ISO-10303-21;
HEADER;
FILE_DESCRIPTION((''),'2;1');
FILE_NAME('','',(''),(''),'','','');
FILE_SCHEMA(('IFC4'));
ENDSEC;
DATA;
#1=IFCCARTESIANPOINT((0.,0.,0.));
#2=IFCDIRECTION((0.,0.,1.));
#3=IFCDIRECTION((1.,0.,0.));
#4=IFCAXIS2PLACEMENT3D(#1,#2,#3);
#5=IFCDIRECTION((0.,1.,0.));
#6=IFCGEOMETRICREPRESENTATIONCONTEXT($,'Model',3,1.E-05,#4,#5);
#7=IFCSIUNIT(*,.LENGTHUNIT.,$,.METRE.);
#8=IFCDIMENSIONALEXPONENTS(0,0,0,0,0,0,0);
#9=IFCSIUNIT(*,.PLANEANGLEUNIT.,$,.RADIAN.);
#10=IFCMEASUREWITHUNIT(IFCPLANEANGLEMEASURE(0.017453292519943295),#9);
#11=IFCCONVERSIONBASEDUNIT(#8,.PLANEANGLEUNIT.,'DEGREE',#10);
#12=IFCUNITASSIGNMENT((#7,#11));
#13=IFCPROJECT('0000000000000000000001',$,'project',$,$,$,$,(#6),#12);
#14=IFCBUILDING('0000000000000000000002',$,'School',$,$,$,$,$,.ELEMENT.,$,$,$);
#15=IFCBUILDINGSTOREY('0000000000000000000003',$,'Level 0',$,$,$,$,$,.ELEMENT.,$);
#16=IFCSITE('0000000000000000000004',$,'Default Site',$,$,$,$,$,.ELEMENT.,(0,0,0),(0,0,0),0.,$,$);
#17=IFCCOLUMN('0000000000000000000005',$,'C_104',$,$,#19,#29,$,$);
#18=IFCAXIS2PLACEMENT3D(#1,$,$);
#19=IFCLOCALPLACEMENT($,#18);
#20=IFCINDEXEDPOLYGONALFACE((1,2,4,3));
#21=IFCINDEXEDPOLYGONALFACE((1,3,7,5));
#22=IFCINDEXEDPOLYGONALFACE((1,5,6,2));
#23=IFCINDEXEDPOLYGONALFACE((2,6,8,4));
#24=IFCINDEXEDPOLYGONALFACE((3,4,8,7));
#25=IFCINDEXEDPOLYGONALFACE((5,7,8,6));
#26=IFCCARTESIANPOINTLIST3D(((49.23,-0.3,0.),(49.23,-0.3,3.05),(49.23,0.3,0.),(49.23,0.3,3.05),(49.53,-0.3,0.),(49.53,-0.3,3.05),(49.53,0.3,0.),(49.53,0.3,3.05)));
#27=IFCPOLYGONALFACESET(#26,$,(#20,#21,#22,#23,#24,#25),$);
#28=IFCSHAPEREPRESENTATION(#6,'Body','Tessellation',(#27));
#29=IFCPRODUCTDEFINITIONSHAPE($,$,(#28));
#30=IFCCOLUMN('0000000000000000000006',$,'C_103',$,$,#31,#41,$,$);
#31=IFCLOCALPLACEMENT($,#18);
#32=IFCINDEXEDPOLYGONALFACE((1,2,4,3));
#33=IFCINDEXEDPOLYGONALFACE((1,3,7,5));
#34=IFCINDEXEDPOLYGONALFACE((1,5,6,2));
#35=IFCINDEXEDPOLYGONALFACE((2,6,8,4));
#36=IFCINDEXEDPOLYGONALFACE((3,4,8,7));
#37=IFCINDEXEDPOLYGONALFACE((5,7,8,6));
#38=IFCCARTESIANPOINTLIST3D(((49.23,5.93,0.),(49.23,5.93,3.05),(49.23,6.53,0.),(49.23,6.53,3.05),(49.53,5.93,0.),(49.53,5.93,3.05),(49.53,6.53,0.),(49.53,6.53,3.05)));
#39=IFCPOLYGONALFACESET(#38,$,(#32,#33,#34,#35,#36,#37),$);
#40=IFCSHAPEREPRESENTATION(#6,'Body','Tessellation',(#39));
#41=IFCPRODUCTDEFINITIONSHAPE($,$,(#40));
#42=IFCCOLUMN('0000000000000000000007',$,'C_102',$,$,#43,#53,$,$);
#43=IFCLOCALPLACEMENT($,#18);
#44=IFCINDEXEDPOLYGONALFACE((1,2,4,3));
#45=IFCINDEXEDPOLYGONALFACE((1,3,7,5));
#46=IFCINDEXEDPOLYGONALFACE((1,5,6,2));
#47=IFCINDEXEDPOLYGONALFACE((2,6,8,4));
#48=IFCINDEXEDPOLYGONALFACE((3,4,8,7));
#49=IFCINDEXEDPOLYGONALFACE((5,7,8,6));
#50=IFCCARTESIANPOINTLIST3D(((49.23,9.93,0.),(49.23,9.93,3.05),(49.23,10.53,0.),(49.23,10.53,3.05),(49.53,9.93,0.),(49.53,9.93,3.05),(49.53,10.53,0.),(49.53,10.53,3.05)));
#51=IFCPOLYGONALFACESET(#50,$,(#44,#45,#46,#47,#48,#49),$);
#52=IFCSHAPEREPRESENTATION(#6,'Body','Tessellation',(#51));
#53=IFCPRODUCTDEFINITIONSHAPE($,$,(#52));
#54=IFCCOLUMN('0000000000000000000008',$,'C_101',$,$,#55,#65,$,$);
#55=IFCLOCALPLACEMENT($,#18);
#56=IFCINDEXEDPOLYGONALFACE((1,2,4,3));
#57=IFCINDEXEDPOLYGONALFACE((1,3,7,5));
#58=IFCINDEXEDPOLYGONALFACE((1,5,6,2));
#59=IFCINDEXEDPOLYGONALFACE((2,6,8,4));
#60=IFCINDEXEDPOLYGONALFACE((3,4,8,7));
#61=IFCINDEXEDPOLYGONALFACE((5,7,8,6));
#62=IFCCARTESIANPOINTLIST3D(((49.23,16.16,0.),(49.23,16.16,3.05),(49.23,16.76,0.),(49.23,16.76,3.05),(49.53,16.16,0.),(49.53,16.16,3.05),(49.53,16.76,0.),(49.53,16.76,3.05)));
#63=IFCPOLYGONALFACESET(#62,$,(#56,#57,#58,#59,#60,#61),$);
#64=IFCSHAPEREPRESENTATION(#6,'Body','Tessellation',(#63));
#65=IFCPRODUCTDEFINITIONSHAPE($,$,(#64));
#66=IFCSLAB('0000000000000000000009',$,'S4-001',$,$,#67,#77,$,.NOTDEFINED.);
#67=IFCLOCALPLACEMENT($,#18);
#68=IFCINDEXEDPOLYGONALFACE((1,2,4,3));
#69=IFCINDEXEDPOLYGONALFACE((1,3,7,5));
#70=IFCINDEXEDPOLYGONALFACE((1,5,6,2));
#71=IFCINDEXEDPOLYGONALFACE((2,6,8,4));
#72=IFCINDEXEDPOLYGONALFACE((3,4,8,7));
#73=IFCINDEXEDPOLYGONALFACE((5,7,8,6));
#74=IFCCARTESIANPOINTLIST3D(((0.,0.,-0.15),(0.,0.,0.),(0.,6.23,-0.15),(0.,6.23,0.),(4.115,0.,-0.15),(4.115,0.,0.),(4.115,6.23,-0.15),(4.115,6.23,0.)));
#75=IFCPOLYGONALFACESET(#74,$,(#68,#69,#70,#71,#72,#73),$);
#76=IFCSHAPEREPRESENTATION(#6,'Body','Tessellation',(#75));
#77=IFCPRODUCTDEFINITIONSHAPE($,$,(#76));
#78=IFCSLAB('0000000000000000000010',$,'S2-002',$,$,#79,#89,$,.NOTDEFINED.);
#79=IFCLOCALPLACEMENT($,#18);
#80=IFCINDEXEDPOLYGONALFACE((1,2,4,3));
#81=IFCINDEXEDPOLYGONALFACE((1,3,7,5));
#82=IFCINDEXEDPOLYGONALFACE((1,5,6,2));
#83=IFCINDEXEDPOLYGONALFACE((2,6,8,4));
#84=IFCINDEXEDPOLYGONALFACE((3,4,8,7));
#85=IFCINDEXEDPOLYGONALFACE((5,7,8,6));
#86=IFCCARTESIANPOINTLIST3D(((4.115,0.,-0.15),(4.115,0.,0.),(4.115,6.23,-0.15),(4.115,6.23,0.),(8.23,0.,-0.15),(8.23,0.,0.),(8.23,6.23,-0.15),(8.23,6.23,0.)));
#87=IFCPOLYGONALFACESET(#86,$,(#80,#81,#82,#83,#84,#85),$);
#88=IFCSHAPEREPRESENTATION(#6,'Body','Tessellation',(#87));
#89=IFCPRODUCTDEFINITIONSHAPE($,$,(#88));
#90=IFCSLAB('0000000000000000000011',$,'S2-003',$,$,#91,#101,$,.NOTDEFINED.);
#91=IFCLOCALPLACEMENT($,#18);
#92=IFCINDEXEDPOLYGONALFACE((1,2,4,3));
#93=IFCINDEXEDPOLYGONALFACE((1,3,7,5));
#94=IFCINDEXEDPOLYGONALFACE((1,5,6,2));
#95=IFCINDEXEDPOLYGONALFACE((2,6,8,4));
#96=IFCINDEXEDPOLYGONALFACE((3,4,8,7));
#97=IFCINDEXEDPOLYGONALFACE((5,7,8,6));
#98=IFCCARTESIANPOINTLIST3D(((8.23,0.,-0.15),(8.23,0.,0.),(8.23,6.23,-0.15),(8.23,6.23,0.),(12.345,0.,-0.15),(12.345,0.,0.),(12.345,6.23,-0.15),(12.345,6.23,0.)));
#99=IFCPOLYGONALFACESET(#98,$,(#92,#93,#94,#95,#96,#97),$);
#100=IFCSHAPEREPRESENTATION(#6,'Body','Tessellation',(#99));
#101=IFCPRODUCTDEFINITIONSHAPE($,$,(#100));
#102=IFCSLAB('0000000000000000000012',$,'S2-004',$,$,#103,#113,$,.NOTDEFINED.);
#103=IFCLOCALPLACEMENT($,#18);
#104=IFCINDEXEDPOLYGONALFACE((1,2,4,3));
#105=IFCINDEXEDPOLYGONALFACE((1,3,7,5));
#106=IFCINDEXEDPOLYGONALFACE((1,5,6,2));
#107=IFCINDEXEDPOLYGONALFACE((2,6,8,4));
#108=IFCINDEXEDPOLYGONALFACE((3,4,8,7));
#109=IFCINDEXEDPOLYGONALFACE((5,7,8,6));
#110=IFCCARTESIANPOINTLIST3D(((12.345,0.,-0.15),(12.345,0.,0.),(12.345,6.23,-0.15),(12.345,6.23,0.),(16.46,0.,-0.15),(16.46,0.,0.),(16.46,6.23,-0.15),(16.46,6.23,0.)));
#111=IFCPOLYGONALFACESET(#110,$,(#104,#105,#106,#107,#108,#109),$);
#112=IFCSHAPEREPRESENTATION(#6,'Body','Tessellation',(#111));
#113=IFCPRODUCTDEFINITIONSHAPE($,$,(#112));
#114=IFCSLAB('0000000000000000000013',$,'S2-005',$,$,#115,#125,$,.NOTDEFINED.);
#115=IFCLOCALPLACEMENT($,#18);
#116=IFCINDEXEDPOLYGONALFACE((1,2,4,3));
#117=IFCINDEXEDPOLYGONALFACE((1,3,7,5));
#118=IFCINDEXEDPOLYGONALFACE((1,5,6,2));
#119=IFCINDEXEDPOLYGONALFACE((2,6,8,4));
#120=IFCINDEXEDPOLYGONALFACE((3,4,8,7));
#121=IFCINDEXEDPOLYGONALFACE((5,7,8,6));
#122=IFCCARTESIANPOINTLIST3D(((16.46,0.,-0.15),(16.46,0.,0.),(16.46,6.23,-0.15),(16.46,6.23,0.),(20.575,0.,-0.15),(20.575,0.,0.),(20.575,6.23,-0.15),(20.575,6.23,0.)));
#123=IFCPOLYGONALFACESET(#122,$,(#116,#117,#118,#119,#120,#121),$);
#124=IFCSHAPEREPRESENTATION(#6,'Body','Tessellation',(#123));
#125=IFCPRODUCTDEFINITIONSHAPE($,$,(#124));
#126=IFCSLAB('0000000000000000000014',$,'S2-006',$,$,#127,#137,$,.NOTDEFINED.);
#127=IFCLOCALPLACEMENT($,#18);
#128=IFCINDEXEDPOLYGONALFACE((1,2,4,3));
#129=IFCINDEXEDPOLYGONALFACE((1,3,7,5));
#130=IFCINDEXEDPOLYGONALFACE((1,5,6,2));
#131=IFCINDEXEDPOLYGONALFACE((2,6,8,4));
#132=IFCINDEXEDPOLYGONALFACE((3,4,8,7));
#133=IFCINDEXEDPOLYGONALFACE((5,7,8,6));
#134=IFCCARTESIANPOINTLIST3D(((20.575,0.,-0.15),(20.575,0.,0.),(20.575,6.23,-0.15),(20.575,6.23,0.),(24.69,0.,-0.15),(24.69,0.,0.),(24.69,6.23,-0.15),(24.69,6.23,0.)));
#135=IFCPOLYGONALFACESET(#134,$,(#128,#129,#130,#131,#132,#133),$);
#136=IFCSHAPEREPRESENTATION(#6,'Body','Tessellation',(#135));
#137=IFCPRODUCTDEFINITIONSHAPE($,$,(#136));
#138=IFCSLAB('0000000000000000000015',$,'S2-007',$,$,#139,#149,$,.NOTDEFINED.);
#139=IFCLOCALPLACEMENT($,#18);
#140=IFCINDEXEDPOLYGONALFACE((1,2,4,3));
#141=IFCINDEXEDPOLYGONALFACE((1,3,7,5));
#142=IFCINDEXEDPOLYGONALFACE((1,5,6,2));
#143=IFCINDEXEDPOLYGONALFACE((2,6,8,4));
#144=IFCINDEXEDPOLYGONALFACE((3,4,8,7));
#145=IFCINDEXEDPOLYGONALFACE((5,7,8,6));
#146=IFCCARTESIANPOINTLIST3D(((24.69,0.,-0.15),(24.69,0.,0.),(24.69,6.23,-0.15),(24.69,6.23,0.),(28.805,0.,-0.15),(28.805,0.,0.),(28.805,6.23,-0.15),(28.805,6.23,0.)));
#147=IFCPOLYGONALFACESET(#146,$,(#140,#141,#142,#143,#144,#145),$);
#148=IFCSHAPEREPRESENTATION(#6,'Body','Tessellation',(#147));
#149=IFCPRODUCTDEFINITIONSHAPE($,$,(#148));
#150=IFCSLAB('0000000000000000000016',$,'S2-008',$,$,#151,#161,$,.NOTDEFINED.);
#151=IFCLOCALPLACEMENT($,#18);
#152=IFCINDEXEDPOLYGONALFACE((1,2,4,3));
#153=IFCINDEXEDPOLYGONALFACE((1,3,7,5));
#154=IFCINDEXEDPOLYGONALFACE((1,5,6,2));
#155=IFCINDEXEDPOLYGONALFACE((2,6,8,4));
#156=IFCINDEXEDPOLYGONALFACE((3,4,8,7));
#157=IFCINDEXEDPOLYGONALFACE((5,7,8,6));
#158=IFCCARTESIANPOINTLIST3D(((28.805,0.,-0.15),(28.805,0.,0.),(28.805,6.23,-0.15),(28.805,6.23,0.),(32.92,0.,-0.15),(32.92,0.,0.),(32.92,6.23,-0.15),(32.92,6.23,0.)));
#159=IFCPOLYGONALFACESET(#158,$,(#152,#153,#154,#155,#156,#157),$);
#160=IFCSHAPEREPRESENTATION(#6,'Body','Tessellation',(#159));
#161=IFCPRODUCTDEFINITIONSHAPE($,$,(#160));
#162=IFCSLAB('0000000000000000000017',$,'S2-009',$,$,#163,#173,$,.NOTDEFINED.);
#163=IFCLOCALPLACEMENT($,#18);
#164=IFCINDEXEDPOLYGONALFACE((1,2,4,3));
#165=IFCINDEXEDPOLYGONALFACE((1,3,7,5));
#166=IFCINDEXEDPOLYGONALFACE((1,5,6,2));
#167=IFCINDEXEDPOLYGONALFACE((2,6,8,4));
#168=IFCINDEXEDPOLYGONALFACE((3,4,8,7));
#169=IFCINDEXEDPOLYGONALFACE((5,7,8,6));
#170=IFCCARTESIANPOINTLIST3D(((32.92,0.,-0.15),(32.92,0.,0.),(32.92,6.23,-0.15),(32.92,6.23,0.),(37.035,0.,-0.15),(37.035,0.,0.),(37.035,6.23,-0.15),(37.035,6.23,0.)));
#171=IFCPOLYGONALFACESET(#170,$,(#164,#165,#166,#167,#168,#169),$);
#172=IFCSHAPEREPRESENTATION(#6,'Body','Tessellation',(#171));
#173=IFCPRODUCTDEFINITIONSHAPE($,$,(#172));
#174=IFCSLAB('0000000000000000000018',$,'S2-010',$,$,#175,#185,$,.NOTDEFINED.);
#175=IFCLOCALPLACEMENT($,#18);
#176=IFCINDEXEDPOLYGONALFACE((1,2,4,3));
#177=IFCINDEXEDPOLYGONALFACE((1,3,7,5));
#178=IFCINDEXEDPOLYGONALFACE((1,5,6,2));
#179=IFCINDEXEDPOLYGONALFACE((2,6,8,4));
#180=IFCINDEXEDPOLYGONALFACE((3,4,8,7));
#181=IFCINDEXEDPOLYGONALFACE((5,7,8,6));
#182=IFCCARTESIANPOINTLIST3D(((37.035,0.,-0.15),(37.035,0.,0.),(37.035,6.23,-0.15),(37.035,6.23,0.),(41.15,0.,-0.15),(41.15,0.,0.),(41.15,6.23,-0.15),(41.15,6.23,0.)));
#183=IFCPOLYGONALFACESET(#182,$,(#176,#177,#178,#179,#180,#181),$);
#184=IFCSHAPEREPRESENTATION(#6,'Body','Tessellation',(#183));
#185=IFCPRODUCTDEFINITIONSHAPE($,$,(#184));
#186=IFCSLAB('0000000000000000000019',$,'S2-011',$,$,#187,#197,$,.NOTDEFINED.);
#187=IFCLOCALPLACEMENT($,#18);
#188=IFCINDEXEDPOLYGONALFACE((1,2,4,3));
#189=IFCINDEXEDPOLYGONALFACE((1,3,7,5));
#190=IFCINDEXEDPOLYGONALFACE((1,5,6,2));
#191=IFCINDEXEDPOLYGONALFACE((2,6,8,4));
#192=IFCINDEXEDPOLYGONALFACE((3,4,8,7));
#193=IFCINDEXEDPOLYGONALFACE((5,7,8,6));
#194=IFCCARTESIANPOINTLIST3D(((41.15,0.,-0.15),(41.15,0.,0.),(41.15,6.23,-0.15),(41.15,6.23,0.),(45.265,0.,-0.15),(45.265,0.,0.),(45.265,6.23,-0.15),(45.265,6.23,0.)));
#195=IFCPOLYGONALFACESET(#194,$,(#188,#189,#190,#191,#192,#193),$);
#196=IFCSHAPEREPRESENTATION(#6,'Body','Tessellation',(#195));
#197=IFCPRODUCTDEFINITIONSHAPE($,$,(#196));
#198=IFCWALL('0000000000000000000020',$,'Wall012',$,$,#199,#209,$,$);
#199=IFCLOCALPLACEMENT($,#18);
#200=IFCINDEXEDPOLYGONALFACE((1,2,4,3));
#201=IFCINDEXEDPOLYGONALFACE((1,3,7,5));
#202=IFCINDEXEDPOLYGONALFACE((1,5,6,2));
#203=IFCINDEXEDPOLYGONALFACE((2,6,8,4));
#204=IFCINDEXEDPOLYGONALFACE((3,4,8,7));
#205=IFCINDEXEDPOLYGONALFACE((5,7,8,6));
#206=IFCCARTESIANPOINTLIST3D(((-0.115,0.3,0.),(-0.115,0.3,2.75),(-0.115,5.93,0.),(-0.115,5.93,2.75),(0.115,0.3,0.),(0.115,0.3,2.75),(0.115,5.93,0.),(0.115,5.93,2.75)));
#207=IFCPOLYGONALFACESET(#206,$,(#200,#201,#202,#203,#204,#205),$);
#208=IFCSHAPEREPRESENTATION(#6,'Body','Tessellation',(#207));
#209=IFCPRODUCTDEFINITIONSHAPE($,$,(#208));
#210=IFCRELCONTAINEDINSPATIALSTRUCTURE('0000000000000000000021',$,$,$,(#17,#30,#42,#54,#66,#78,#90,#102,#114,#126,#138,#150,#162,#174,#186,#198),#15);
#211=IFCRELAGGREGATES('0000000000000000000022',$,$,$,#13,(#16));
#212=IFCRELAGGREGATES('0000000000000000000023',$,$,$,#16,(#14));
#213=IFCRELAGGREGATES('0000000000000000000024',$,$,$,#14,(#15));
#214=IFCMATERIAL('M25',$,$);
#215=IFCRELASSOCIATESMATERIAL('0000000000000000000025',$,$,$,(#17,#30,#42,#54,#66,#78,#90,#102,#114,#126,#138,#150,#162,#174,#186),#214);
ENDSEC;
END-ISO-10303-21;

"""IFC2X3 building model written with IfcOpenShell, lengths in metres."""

from ifc_helpers import new_model, entity, si_unit, converted_unit, direction, frame, frame_2d, origin_with_axes, place, context, project, spatial, rectangle, extrude, material, element, save


model = new_model("IFC2X3")

# Units and contexts
model_context = context("Model", 3, precision=1e-05, world=origin_with_axes(), true_north=direction((0.0, 1.0, 0.0)))
ifc_project = project(units=[si_unit("LENGTHUNIT", "METRE"), converted_unit("PLANEANGLEUNIT", "DEGREE", entity("IfcPlaneAngleMeasure", 0.017453292519943295), si_unit("PLANEANGLEUNIT", "RADIAN"), dimensions=[0, 0, 0, 0, 0, 0, 0])], contexts=[model_context])

# Site, building, storey
site = spatial("IfcSite", under=ifc_project, Name="Default Site", CompositionType="ELEMENT", RefLatitude=(0, 0, 0), RefLongitude=(0, 0, 0), RefElevation=0.0)
building = spatial("IfcBuilding", under=site, Name="School", CompositionType="ELEMENT")
storey = spatial("IfcBuildingStorey", under=building, Name="Level 0", CompositionType="ELEMENT")

# Columns
ifc_material = material(Name="M25")
placement = place(None, origin_with_axes())
element("IfcColumn", 1, at=placement, inside=storey, material=ifc_material, Name="C_104", context=model_context, shape_type="SweptSolid", body=[
    extrude(rectangle(XDim=0.3, YDim=0.6, at=frame_2d((0.0, 0.0), x_axis=(1.0, 0.0, 0.0))), frame((49.38, 0.0, 0.0), z_axis=(0.0, 0.0, 1.0), x_axis=(1.0, 0.0, 0.0)), (0.0, 0.0, 1.0), 3.05),
])
element("IfcColumn", 2, at=placement, inside=storey, material=ifc_material, Name="C_103", context=model_context, shape_type="SweptSolid", body=[
    extrude(rectangle(XDim=0.3, YDim=0.6, at=frame_2d((0.0, 0.0), x_axis=(1.0, 0.0, 0.0))), frame((49.38, 6.23, 0.0), z_axis=(0.0, 0.0, 1.0), x_axis=(1.0, 0.0, 0.0)), (0.0, 0.0, 1.0), 3.05),
])
element("IfcColumn", 3, at=placement, inside=storey, material=ifc_material, Name="C_102", context=model_context, shape_type="SweptSolid", body=[
    extrude(rectangle(XDim=0.3, YDim=0.6, at=frame_2d((0.0, 0.0), x_axis=(1.0, 0.0, 0.0))), frame((49.38, 10.23, 0.0), z_axis=(0.0, 0.0, 1.0), x_axis=(1.0, 0.0, 0.0)), (0.0, 0.0, 1.0), 3.05),
])
element("IfcColumn", 4, at=placement, inside=storey, material=ifc_material, Name="C_101", context=model_context, shape_type="SweptSolid", body=[
    extrude(rectangle(XDim=0.3, YDim=0.6, at=frame_2d((0.0, 0.0), x_axis=(1.0, 0.0, 0.0))), frame((49.38, 16.46, 0.0), z_axis=(0.0, 0.0, 1.0), x_axis=(1.0, 0.0, 0.0)), (0.0, 0.0, 1.0), 3.05),
])

# Slabs
element("IfcSlab", 5, at=placement, inside=storey, material=ifc_material, Name="S4-001", PredefinedType="NOTDEFINED", context=model_context, shape_type="SweptSolid", body=[
    extrude(rectangle(XDim=4.115, YDim=6.23, at=frame_2d((0.0, 0.0), x_axis=(1.0, 0.0, 0.0))), frame((2.0575, 3.115, -0.15), z_axis=(0.0, 0.0, 1.0), x_axis=(1.0, 0.0, 0.0)), (0.0, 0.0, 1.0), 0.15),
])
element("IfcSlab", 6, at=placement, inside=storey, material=ifc_material, Name="S2-002", PredefinedType="NOTDEFINED", context=model_context, shape_type="SweptSolid", body=[
    extrude(rectangle(XDim=4.115, YDim=6.23, at=frame_2d((0.0, 0.0), x_axis=(1.0, 0.0, 0.0))), frame((6.1725, 3.115, -0.15), z_axis=(0.0, 0.0, 1.0), x_axis=(1.0, 0.0, 0.0)), (0.0, 0.0, 1.0), 0.15),
])
element("IfcSlab", 7, at=placement, inside=storey, material=ifc_material, Name="S2-003", PredefinedType="NOTDEFINED", context=model_context, shape_type="SweptSolid", body=[
    extrude(rectangle(XDim=4.115, YDim=6.23, at=frame_2d((0.0, 0.0), x_axis=(1.0, 0.0, 0.0))), frame((10.2875, 3.115, -0.15), z_axis=(0.0, 0.0, 1.0), x_axis=(1.0, 0.0, 0.0)), (0.0, 0.0, 1.0), 0.15),
])
element("IfcSlab", 8, at=placement, inside=storey, material=ifc_material, Name="S2-004", PredefinedType="NOTDEFINED", context=model_context, shape_type="SweptSolid", body=[
    extrude(rectangle(XDim=4.115, YDim=6.23, at=frame_2d((0.0, 0.0), x_axis=(1.0, 0.0, 0.0))), frame((14.4025, 3.115, -0.15), z_axis=(0.0, 0.0, 1.0), x_axis=(1.0, 0.0, 0.0)), (0.0, 0.0, 1.0), 0.15),
])
element("IfcSlab", 9, at=placement, inside=storey, material=ifc_material, Name="S2-005", PredefinedType="NOTDEFINED", context=model_context, shape_type="SweptSolid", body=[
    extrude(rectangle(XDim=4.115, YDim=6.23, at=frame_2d((0.0, 0.0), x_axis=(1.0, 0.0, 0.0))), frame((18.5175, 3.115, -0.15), z_axis=(0.0, 0.0, 1.0), x_axis=(1.0, 0.0, 0.0)), (0.0, 0.0, 1.0), 0.15),
])
element("IfcSlab", 10, at=placement, inside=storey, material=ifc_material, Name="S2-006", PredefinedType="NOTDEFINED", context=model_context, shape_type="SweptSolid", body=[
    extrude(rectangle(XDim=4.115, YDim=6.23, at=frame_2d((0.0, 0.0), x_axis=(1.0, 0.0, 0.0))), frame((22.6325, 3.115, -0.15), z_axis=(0.0, 0.0, 1.0), x_axis=(1.0, 0.0, 0.0)), (0.0, 0.0, 1.0), 0.15),
])
element("IfcSlab", 11, at=placement, inside=storey, material=ifc_material, Name="S2-007", PredefinedType="NOTDEFINED", context=model_context, shape_type="SweptSolid", body=[
    extrude(rectangle(XDim=4.115, YDim=6.23, at=frame_2d((0.0, 0.0), x_axis=(1.0, 0.0, 0.0))), frame((26.7475, 3.115, -0.15), z_axis=(0.0, 0.0, 1.0), x_axis=(1.0, 0.0, 0.0)), (0.0, 0.0, 1.0), 0.15),
])
element("IfcSlab", 12, at=placement, inside=storey, material=ifc_material, Name="S2-008", PredefinedType="NOTDEFINED", context=model_context, shape_type="SweptSolid", body=[
    extrude(rectangle(XDim=4.115, YDim=6.23, at=frame_2d((0.0, 0.0), x_axis=(1.0, 0.0, 0.0))), frame((30.8625, 3.115, -0.15), z_axis=(0.0, 0.0, 1.0), x_axis=(1.0, 0.0, 0.0)), (0.0, 0.0, 1.0), 0.15),
])
element("IfcSlab", 13, at=placement, inside=storey, material=ifc_material, Name="S2-009", PredefinedType="NOTDEFINED", context=model_context, shape_type="SweptSolid", body=[
    extrude(rectangle(XDim=4.115, YDim=6.23, at=frame_2d((0.0, 0.0), x_axis=(1.0, 0.0, 0.0))), frame((34.9775, 3.115, -0.15), z_axis=(0.0, 0.0, 1.0), x_axis=(1.0, 0.0, 0.0)), (0.0, 0.0, 1.0), 0.15),
])
element("IfcSlab", 14, at=placement, inside=storey, material=ifc_material, Name="S2-010", PredefinedType="NOTDEFINED", context=model_context, shape_type="SweptSolid", body=[
    extrude(rectangle(XDim=4.115, YDim=6.23, at=frame_2d((0.0, 0.0), x_axis=(1.0, 0.0, 0.0))), frame((39.0925, 3.115, -0.15), z_axis=(0.0, 0.0, 1.0), x_axis=(1.0, 0.0, 0.0)), (0.0, 0.0, 1.0), 0.15),
])
element("IfcSlab", 15, at=placement, inside=storey, material=ifc_material, Name="S2-011", PredefinedType="NOTDEFINED", context=model_context, shape_type="SweptSolid", body=[
    extrude(rectangle(XDim=4.115, YDim=6.23, at=frame_2d((0.0, 0.0), x_axis=(1.0, 0.0, 0.0))), frame((43.2075, 3.115, -0.15), z_axis=(0.0, 0.0, 1.0), x_axis=(1.0, 0.0, 0.0)), (0.0, 0.0, 1.0), 0.15),
])

# Wall
element("IfcWall", 16, at=placement, inside=storey, Name="Wall012", context=model_context, shape_type="SweptSolid", body=[
    extrude(rectangle(XDim=5.63, YDim=0.23, at=frame_2d((0.0, 0.0), x_axis=(0.0, 1.0, 0.0))), frame((0.0, 3.115, 0.0), z_axis=(0.0, 0.0, 1.0), x_axis=(1.0, 0.0, 0.0)), (0.0, 0.0, 1.0), 2.75),
])

save(model, "model.ifc")
